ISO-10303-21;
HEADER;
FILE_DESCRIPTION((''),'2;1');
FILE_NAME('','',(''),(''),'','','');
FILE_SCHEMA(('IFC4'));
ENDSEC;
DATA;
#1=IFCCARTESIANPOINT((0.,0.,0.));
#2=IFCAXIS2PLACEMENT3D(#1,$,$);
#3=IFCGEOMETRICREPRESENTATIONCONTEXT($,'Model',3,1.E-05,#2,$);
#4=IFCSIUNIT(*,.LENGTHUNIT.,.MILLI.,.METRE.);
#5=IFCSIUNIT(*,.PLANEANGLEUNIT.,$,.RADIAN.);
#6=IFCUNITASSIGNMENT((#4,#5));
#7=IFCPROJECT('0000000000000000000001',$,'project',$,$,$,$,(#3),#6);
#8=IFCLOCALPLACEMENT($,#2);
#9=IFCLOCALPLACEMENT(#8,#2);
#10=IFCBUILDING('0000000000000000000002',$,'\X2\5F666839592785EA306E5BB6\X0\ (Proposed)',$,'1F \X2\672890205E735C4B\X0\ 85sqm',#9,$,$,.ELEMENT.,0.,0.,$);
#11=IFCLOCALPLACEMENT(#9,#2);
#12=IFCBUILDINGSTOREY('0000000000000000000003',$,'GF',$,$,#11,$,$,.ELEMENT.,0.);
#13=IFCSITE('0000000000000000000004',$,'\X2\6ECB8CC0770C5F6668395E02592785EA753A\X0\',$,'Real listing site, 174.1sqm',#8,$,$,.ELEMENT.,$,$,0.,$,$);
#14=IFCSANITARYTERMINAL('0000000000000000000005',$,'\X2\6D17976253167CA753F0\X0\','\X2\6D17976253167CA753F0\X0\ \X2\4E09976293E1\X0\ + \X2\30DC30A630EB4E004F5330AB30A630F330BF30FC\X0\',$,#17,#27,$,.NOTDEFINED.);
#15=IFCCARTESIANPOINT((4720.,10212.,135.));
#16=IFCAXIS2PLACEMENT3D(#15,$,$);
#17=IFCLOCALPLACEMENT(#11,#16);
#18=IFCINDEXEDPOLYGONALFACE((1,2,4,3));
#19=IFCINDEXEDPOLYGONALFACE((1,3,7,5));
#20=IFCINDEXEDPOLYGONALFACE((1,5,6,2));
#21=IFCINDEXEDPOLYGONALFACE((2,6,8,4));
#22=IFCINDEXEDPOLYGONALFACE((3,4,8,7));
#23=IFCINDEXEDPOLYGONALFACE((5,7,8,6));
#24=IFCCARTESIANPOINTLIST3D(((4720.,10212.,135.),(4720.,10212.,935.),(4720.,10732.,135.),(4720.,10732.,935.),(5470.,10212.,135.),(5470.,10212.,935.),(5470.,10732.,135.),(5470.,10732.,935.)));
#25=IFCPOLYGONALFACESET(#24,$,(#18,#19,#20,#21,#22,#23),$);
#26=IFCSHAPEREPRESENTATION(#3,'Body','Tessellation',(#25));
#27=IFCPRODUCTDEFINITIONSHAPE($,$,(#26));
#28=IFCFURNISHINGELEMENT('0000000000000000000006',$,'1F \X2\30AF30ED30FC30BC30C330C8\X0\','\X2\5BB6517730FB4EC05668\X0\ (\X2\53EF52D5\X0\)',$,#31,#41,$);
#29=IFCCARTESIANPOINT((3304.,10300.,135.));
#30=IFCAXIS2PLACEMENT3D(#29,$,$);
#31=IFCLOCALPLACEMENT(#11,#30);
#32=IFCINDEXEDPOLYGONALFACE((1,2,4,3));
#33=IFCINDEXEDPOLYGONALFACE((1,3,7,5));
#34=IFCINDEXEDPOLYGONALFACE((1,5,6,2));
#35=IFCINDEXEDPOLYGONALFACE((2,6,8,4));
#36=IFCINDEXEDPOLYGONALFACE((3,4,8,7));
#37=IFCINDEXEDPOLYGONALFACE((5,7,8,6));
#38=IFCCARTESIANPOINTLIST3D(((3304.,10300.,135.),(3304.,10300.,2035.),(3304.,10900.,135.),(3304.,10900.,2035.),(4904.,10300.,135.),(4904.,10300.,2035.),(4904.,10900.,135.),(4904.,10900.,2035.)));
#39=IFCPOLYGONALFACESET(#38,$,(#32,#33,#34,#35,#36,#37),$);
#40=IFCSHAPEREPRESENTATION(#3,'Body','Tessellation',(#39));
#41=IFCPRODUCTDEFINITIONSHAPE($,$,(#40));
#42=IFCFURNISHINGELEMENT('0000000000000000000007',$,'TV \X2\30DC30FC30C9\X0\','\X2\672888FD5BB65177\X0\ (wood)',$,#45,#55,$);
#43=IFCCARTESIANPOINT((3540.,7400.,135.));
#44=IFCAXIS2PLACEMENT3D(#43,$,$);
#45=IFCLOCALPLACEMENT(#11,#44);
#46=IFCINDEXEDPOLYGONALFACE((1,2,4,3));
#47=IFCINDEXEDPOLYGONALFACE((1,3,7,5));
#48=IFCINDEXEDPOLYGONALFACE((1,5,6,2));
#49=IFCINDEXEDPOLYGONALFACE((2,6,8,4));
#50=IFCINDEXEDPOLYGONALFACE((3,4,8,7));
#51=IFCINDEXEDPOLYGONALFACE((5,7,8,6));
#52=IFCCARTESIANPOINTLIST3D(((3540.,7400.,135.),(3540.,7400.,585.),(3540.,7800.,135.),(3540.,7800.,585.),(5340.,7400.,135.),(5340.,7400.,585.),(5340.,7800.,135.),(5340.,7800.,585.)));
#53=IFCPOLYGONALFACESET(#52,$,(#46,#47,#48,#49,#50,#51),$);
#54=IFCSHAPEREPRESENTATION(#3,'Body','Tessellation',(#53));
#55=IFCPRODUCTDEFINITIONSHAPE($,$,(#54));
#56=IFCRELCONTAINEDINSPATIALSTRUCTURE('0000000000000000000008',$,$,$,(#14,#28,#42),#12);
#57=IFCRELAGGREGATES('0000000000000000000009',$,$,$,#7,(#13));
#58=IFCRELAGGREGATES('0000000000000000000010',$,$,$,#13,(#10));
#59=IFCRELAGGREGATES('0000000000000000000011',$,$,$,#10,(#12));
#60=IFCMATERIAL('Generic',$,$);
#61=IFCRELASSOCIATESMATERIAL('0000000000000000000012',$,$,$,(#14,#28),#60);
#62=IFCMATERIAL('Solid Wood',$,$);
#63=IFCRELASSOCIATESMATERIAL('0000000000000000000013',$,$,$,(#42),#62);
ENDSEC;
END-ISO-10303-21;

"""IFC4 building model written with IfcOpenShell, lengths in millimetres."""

from ifc_helpers import new_model, si_unit, frame, frame_2d, origin, place, context, project, spatial, rectangle, extrude, material, element, save


model = new_model("IFC4")

# Units and contexts
model_context = context("Model", 3, precision=1e-05, world=origin())
ifc_project = project(units=[si_unit("LENGTHUNIT", "METRE", prefix="MILLI"), si_unit("PLANEANGLEUNIT", "RADIAN")], contexts=[model_context])

# Site, building, storey
site_placement = place(None, origin())
site = spatial("IfcSite", under=ifc_project, at=site_placement, Name="滋賀県彦根市大藪町", ObjectType="Real listing site, 174.1sqm", CompositionType="ELEMENT", RefElevation=0.0)
building_placement = place(site_placement, origin())
building = spatial("IfcBuilding", under=site, at=building_placement, Name="彦根大藪の家 (Proposed)", ObjectType="1F 木造平屋 85sqm", CompositionType="ELEMENT", ElevationOfRefHeight=0.0, ElevationOfTerrain=0.0)
storey_placement = place(building_placement, origin())
storey = spatial("IfcBuildingStorey", under=building, at=storey_placement, Name="GF", CompositionType="ELEMENT", Elevation=0.0)

# Shared definitions
ifc_material_1 = material(Name="Solid Wood")

# Shared definitions
ifc_material_2 = material(Name="Generic")

# Sanitary terminal
sanitary_terminal_1_placement = place(storey_placement, frame((4720.0, 10212.0, 135.0)))
element("IfcSanitaryTerminal", 1, at=sanitary_terminal_1_placement, inside=storey, material=ifc_material_2, Name="洗面化粧台", Description="洗面化粧台 三面鏡 + ボウル一体カウンター", PredefinedType="NOTDEFINED", context=model_context, shape_type="SweptSolid", body=[
    extrude(rectangle(XDim=750.0, YDim=520.0, at=frame_2d((375.0, 260.0))), frame((4720.0, 10212.0, 135.0)), (0.0, 0.0, 1.0), 800.0),
])

# Furnishing elements
furnishing_1_placement = place(storey_placement, frame((3304.0, 10300.0, 135.0)))
element("IfcFurnishingElement", 2, at=furnishing_1_placement, inside=storey, material=ifc_material_2, Name="1F クローゼット", Description="家具・什器 (可動)", context=model_context, shape_type="SweptSolid", body=[
    extrude(rectangle(XDim=1600.0, YDim=600.0, at=frame_2d((800.0, 300.0))), frame((3304.0, 10300.0, 135.0)), (0.0, 0.0, 1.0), 1900.0),
])
furnishing_2_placement = place(storey_placement, frame((3540.0, 7400.0, 135.0)))
element("IfcFurnishingElement", 3, at=furnishing_2_placement, inside=storey, material=ifc_material_1, Name="TV ボード", Description="木製家具 (wood)", context=model_context, shape_type="SweptSolid", body=[
    extrude(rectangle(XDim=1800.0, YDim=400.0, at=frame_2d((900.0, 200.0))), frame((3540.0, 7400.0, 135.0)), (0.0, 0.0, 1.0), 450.0),
])

save(model, "model.ifc")
